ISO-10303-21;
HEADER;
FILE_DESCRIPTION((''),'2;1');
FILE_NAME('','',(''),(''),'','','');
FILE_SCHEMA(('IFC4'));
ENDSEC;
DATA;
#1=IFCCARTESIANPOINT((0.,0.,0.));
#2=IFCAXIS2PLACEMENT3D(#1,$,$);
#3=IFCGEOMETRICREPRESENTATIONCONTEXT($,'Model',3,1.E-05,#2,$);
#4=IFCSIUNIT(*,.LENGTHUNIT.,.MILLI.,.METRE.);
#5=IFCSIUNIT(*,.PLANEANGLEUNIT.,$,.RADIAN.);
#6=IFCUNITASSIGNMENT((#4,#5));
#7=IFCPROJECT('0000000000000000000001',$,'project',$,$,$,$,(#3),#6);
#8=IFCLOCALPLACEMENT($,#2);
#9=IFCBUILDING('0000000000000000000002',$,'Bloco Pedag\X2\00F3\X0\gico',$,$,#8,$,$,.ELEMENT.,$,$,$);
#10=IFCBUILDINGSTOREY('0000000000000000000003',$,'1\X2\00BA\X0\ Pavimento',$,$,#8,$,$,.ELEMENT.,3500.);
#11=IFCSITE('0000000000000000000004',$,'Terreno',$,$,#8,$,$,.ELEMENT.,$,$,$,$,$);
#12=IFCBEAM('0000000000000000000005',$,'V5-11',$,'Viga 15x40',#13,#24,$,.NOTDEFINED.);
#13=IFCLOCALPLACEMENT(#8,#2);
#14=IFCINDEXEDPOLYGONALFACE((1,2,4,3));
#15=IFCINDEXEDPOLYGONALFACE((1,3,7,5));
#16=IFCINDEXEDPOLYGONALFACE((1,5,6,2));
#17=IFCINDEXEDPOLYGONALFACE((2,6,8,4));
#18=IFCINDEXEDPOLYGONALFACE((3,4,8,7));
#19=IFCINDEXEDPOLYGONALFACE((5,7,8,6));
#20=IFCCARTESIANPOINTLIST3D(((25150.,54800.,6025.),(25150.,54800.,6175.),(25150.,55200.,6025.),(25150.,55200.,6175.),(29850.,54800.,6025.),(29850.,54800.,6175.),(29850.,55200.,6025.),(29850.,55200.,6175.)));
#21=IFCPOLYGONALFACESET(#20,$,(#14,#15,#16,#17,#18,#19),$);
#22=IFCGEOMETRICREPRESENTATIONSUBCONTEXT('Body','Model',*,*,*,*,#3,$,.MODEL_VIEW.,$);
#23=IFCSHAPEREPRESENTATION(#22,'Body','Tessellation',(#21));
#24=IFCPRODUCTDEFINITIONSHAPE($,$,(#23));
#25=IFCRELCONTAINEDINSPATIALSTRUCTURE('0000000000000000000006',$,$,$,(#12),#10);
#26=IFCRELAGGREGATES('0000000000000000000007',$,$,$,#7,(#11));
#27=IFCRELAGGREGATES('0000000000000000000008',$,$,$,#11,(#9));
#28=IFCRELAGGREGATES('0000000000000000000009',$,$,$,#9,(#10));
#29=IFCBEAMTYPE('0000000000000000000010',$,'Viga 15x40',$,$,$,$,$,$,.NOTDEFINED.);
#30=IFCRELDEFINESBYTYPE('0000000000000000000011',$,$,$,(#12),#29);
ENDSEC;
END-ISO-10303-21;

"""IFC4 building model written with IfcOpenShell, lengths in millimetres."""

from ifc_helpers import new_model, si_unit, frame, origin, origin_2d, place, context, subcontext, project, spatial, rectangle, extrude, type_object, element, save


model = new_model("IFC4")

# Units and contexts
model_context = context("Model", 3, precision=1e-05, world=origin())
body_context = subcontext(model_context, "Body", "Model", "MODEL_VIEW")
ifc_project = project(units=[si_unit("LENGTHUNIT", "METRE", prefix="MILLI"), si_unit("PLANEANGLEUNIT", "RADIAN")], contexts=[model_context])

# Site, building, storey
placement = place(None, origin())
site = spatial("IfcSite", under=ifc_project, at=placement, Name="Terreno", CompositionType="ELEMENT")
building = spatial("IfcBuilding", under=site, at=placement, Name="Bloco Pedagógico", CompositionType="ELEMENT")
storey = spatial("IfcBuildingStorey", under=building, at=placement, Name="1º Pavimento", CompositionType="ELEMENT", Elevation=3500.0)

# Beam
beam_type = type_object("IfcBeamType", Name="Viga 15x40", PredefinedType="NOTDEFINED")
for number, where, z_axis, x_axis, name in (
    (1, (25150.0, 55000.0, 6100.0), (1.0, 0.0, 0.0), (0.0, 1.0, 0.0), "V5-11"),
):
    element("IfcBeam", number, at=place(None, frame(where, z_axis=z_axis, x_axis=x_axis)), inside=storey, type_object=beam_type, Name=name, ObjectType="Viga 15x40", PredefinedType="NOTDEFINED", context=body_context, shape_type="SweptSolid", body=[
        extrude(rectangle(XDim=400.0, YDim=150.0, at=origin_2d()), None, (0.0, 0.0, 1.0), 4700.0),
    ])

save(model, "model.ifc")
